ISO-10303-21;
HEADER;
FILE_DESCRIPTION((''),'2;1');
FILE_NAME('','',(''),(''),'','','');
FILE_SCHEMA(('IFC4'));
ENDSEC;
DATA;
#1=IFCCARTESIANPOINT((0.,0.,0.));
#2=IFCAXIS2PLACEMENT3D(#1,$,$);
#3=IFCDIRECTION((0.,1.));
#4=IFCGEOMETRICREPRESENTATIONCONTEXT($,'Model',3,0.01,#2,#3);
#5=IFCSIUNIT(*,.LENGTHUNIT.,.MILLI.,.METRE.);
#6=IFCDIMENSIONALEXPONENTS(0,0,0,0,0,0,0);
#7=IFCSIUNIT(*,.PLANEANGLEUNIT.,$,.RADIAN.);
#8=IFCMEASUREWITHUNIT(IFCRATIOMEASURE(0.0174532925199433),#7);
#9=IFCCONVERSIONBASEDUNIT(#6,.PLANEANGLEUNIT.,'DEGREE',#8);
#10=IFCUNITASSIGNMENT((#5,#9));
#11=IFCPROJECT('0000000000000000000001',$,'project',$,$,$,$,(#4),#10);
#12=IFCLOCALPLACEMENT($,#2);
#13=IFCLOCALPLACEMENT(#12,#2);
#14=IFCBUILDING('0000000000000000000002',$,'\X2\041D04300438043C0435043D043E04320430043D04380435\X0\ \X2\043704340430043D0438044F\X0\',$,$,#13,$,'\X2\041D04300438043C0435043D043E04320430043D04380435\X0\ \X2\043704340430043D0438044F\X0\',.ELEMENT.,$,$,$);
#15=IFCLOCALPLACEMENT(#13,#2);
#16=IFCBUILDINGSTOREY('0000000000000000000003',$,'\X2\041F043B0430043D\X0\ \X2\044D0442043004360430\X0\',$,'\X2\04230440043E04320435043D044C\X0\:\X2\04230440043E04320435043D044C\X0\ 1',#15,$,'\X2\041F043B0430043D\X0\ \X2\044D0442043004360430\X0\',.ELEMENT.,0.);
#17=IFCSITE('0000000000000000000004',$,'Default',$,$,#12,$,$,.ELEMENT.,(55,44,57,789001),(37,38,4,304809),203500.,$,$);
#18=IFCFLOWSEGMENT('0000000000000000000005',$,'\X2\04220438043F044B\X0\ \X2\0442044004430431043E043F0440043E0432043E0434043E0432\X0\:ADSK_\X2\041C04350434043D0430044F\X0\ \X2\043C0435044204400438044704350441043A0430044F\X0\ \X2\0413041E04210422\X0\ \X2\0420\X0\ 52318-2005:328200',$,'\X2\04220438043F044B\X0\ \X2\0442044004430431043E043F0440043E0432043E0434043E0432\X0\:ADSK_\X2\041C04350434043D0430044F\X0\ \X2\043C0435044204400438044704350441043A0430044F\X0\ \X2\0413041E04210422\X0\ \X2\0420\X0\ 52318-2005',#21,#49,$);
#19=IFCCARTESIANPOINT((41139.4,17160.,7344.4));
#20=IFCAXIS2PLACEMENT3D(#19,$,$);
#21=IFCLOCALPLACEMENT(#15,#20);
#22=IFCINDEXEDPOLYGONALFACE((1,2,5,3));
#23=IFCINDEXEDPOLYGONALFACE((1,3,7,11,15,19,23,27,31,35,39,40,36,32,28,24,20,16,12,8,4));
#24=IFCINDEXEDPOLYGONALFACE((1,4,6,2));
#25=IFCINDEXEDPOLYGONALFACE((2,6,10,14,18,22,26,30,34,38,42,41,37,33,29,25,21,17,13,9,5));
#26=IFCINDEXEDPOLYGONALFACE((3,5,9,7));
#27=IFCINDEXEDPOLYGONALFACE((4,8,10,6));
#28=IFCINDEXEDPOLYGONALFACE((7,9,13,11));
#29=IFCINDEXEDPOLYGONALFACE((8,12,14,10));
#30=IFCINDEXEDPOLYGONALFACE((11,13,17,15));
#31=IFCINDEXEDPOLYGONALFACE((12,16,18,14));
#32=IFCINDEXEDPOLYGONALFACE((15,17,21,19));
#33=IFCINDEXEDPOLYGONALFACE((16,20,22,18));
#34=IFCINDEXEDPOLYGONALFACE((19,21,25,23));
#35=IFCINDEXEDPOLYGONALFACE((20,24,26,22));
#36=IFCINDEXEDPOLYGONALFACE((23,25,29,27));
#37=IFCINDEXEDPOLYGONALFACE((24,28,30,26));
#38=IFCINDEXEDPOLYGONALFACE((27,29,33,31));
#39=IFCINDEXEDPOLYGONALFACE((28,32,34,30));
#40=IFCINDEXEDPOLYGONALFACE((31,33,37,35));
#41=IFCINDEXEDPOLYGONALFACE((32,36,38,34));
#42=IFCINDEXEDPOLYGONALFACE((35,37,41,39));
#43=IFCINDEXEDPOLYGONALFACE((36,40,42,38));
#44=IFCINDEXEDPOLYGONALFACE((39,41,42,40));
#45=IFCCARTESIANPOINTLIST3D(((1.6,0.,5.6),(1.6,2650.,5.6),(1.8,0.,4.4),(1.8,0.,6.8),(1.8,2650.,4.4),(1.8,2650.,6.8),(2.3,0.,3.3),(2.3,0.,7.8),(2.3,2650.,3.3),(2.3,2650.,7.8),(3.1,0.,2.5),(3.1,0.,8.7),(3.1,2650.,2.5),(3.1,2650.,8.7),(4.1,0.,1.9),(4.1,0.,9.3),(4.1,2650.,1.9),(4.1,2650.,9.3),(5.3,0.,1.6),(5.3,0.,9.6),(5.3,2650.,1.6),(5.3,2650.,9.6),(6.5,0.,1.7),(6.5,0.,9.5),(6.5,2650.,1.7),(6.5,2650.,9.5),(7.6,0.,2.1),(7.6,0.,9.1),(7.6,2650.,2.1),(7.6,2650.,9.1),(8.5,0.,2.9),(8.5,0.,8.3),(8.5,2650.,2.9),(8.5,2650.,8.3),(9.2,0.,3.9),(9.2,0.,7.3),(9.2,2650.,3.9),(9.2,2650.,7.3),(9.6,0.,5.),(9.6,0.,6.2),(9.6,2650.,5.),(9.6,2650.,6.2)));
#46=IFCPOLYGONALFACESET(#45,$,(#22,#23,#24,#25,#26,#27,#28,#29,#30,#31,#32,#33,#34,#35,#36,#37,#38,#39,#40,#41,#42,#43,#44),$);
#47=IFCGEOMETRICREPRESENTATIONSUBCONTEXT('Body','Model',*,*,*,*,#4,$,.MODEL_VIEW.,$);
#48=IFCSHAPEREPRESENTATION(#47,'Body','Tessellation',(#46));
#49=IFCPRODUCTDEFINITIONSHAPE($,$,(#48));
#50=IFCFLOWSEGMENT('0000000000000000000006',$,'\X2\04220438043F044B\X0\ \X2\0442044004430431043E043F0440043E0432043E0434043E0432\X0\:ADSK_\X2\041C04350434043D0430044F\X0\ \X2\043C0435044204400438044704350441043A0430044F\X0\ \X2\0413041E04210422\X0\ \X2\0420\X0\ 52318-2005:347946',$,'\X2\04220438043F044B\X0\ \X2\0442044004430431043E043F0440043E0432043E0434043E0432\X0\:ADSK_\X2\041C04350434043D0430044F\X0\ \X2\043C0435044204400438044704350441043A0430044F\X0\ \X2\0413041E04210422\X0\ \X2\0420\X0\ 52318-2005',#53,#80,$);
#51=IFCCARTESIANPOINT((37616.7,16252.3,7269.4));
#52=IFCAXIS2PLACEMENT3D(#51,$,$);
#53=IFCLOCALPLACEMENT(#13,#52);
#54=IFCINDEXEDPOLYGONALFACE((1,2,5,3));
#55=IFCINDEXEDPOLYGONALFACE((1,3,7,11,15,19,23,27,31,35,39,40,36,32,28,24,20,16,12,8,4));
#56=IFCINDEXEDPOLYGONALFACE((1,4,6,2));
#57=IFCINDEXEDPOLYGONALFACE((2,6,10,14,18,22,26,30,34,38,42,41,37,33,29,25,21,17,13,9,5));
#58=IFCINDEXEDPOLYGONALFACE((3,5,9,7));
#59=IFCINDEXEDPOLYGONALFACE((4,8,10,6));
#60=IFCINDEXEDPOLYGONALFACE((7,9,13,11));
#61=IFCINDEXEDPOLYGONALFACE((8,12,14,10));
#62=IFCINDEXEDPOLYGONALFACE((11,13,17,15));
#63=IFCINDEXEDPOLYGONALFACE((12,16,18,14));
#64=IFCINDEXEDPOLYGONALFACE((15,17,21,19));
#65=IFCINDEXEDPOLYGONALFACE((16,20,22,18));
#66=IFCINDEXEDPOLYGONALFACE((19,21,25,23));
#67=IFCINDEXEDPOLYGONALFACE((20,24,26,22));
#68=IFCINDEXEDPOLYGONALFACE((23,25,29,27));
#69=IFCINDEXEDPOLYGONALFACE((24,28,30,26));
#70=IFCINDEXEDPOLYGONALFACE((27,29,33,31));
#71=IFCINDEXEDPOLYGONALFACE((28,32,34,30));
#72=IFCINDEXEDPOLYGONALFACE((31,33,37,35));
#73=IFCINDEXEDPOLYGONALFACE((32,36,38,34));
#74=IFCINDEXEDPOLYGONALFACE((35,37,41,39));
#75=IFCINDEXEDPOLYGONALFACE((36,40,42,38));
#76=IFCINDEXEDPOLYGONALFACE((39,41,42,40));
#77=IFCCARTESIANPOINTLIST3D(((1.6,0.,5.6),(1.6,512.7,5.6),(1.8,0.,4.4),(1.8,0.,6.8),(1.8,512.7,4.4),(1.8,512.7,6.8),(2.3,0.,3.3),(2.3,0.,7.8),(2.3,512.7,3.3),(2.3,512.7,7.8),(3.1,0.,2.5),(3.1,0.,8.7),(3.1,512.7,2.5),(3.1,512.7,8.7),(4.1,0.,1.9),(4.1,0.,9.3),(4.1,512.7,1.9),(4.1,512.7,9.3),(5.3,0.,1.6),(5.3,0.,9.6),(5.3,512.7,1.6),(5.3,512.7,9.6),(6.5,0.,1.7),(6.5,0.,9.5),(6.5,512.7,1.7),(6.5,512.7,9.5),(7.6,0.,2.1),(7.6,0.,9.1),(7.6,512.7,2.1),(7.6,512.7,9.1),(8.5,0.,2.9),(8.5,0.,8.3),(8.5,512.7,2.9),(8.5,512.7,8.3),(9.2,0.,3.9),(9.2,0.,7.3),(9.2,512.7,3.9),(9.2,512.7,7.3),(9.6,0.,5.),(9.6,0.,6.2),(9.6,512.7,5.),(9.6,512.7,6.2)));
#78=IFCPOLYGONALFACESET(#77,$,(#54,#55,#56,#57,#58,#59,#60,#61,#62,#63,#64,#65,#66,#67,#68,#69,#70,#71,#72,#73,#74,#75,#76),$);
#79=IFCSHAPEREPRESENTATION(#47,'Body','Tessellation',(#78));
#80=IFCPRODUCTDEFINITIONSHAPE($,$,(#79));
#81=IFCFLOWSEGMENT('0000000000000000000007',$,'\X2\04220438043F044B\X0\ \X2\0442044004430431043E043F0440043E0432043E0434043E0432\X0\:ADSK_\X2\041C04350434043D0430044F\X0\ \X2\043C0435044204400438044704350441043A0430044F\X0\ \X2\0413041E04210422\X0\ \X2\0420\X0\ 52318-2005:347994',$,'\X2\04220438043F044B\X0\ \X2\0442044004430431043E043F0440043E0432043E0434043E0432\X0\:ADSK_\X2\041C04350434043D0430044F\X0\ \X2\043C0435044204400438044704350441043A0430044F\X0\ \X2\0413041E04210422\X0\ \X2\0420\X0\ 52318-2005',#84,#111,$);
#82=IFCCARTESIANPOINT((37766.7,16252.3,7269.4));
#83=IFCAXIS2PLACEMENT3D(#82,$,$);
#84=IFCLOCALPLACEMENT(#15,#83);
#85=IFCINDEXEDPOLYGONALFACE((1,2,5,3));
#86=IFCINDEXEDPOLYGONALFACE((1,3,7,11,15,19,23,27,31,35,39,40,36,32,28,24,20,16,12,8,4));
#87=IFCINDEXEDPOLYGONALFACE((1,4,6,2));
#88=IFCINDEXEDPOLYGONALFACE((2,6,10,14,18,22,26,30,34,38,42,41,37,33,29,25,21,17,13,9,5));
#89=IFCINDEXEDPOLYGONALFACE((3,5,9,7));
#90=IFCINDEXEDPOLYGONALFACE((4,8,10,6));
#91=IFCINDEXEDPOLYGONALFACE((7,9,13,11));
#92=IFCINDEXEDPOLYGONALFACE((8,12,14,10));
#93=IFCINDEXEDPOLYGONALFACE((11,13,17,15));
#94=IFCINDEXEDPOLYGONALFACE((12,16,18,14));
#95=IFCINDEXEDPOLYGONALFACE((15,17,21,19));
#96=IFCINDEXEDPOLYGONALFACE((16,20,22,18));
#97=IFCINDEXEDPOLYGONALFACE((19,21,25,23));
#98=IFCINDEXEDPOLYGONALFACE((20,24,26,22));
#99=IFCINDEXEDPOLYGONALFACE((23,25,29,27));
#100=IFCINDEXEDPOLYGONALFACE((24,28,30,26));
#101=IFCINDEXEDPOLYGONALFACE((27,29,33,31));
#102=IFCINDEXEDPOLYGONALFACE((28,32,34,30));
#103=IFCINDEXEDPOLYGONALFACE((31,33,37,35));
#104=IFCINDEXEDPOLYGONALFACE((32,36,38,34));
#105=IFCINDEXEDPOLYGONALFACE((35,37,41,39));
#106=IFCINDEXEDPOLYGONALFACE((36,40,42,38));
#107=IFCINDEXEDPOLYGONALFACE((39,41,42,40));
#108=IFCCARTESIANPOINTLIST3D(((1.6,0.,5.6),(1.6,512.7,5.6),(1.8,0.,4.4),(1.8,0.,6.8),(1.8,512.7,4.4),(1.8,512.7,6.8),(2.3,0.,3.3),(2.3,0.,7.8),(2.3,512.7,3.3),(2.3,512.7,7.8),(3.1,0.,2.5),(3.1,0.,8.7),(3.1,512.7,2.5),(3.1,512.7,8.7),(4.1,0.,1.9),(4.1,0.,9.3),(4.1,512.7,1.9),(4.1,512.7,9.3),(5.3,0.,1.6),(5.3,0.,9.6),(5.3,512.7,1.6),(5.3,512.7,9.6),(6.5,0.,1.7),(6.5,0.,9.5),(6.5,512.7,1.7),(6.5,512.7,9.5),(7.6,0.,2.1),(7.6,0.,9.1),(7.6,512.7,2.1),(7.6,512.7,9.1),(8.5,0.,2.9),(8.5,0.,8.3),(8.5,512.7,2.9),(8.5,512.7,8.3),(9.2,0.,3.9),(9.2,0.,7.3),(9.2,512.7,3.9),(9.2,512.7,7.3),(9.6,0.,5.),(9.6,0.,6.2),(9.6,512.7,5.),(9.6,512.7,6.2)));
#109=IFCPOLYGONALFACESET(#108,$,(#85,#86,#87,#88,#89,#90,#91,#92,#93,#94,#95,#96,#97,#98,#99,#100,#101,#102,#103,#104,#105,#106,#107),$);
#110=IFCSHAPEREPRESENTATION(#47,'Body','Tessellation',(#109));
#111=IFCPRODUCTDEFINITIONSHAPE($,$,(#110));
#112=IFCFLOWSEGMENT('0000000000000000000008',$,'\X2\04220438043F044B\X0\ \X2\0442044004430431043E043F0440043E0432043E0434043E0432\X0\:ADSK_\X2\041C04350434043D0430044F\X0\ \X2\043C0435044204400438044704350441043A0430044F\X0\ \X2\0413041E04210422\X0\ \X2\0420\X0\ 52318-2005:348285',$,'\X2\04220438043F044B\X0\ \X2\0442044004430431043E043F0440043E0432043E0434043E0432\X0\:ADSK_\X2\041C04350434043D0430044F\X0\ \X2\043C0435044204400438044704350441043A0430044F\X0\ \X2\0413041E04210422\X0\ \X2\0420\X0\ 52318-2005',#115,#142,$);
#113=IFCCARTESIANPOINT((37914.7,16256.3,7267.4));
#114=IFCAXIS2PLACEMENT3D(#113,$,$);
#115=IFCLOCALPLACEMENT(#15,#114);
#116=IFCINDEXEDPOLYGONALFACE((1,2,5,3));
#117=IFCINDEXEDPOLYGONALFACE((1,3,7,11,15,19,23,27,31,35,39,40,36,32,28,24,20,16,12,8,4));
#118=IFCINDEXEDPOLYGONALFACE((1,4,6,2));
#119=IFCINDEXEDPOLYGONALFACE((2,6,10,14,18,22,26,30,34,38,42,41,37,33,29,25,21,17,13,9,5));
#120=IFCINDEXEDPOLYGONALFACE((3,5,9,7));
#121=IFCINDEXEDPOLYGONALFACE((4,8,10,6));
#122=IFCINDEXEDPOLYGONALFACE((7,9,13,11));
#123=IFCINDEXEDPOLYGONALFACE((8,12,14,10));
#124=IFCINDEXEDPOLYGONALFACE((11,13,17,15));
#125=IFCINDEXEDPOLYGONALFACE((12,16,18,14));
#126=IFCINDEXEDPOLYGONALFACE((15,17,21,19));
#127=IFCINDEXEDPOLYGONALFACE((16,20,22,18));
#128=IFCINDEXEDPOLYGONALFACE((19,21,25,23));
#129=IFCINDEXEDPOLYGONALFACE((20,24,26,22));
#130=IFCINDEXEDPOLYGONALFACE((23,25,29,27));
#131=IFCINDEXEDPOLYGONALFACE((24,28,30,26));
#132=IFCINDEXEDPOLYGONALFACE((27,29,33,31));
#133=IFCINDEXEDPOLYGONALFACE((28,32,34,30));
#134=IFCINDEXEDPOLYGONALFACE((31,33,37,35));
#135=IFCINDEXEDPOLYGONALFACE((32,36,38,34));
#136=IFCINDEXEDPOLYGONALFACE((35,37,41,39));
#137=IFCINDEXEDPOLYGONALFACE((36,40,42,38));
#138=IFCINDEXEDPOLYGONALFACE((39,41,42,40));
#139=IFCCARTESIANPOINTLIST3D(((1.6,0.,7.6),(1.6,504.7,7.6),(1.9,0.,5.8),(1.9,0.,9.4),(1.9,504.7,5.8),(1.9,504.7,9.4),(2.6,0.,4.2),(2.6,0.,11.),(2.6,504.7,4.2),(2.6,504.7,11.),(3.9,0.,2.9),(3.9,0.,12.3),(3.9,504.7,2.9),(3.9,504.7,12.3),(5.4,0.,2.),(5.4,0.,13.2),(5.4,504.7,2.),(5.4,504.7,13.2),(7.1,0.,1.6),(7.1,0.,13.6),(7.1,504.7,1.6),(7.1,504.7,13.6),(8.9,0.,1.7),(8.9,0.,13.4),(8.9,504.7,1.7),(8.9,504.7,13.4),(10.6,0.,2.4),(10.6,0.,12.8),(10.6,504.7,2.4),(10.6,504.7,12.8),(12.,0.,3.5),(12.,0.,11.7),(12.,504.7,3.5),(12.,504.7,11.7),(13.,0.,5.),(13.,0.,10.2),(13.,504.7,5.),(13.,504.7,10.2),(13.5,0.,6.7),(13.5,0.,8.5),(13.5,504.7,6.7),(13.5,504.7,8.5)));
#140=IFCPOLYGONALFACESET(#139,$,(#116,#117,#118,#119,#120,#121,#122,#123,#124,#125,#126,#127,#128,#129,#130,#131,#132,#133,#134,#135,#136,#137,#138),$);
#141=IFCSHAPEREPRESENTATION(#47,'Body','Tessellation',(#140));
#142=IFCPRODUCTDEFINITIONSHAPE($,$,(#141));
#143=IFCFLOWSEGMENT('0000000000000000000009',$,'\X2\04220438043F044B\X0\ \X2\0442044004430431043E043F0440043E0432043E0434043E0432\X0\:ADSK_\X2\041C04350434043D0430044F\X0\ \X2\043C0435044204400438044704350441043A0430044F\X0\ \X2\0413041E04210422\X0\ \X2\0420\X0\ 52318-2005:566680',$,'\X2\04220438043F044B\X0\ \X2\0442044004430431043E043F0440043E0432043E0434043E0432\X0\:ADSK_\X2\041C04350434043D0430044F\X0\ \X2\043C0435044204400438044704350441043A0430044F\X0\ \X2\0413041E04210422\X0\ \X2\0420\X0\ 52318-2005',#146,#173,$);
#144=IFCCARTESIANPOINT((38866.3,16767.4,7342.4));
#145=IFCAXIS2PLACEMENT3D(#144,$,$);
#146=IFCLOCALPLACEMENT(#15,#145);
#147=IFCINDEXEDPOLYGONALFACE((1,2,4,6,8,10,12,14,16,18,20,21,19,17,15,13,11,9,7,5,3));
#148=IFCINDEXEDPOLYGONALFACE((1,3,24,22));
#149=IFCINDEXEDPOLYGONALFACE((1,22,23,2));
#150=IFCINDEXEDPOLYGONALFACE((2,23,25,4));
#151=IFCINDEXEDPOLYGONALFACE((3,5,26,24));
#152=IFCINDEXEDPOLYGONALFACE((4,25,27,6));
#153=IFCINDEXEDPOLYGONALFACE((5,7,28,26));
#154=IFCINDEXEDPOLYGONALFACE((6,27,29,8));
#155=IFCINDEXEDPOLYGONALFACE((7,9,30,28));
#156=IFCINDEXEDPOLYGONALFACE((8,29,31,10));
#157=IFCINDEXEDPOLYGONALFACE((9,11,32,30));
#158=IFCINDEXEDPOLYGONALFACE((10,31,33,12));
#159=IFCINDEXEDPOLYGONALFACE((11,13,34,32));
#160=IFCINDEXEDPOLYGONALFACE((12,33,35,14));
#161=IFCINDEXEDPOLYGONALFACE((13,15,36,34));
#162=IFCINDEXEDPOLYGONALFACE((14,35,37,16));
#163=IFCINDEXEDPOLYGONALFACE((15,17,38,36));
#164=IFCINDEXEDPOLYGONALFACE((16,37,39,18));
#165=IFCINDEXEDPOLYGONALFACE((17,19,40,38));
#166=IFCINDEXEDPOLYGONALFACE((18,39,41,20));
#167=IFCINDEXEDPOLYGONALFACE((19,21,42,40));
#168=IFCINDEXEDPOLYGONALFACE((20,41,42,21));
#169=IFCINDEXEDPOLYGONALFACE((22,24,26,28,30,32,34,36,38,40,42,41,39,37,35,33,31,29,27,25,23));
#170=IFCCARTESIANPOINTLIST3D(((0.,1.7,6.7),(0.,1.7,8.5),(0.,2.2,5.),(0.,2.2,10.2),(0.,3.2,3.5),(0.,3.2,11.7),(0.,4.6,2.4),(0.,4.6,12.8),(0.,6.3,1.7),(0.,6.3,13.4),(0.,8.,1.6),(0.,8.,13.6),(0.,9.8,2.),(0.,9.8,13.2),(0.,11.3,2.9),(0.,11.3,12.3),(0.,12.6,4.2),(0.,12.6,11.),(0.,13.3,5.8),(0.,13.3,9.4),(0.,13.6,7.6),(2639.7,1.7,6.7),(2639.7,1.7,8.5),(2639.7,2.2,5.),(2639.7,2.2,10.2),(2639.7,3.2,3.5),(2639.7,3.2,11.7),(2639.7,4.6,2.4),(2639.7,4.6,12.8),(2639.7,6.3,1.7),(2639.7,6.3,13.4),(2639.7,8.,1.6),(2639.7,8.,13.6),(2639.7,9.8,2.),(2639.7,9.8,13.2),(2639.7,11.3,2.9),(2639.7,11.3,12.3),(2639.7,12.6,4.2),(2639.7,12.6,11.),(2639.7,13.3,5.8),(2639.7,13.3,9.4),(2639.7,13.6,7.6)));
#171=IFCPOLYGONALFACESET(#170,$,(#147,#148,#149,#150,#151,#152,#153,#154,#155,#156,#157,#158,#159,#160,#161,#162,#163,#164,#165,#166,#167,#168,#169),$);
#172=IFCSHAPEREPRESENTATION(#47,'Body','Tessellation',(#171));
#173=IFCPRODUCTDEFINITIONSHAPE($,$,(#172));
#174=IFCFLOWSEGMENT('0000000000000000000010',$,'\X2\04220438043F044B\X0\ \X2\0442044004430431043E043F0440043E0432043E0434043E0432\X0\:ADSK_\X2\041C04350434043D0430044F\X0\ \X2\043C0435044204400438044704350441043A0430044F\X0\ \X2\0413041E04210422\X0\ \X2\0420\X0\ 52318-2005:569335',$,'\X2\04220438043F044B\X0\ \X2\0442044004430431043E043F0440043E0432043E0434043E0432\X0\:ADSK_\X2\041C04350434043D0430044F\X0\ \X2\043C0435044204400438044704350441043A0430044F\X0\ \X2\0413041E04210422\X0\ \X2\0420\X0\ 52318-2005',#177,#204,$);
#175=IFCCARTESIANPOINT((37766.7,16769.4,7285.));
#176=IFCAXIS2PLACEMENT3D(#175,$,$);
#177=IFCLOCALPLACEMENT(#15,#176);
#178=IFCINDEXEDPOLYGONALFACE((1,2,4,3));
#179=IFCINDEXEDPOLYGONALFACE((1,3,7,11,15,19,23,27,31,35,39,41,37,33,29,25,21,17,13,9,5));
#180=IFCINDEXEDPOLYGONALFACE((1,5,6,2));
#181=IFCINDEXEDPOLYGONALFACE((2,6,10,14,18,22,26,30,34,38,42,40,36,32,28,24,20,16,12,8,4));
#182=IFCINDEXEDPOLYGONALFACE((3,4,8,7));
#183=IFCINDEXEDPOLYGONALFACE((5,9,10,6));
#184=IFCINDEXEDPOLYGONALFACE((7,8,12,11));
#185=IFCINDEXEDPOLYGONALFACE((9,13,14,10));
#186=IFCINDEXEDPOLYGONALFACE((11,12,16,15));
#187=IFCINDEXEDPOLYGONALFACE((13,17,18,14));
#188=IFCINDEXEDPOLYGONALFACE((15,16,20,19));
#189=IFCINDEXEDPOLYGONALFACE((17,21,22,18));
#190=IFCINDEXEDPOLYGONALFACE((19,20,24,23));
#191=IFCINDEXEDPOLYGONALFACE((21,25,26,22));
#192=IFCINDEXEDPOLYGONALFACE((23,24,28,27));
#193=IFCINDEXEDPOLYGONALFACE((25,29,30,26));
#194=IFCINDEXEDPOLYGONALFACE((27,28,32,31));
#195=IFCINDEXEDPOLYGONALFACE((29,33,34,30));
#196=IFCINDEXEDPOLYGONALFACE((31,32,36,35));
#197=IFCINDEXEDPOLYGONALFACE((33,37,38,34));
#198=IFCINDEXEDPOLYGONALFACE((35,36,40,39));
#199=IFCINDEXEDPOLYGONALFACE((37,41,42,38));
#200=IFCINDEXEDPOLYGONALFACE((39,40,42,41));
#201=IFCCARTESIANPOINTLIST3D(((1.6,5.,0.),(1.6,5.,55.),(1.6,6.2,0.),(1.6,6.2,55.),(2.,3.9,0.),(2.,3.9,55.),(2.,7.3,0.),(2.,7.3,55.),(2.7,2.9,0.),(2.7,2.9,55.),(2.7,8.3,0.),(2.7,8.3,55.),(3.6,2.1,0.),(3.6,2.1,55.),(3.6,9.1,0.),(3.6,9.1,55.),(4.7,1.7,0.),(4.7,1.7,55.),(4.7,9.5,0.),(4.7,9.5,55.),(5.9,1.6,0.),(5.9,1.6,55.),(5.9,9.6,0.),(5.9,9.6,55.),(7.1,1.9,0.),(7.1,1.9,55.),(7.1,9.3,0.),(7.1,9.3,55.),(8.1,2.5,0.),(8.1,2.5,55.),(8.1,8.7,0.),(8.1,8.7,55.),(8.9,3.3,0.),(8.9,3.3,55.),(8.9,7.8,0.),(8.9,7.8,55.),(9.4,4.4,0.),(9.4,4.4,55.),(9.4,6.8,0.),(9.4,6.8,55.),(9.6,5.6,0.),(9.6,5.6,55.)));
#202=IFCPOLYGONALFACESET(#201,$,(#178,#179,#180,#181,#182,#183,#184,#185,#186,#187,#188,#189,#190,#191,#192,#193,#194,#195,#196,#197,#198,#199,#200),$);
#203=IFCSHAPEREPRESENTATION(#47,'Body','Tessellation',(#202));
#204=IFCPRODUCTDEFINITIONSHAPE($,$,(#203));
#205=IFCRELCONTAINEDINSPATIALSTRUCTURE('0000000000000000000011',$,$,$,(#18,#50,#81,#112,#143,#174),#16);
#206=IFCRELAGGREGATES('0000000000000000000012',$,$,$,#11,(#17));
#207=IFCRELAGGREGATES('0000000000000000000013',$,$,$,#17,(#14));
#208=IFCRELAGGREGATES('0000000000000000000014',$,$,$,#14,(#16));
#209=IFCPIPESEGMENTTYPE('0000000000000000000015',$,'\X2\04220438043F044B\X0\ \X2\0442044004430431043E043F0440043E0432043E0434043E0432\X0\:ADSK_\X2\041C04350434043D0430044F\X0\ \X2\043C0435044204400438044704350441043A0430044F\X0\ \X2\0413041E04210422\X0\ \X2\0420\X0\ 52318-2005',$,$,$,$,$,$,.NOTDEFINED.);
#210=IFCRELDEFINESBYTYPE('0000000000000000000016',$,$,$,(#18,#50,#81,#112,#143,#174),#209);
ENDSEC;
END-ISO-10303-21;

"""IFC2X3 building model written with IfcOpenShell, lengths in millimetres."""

from ifc_helpers import new_model, entity, si_unit, converted_unit, direction, frame, frame_2d, origin, origin_2d_with_axis, place, context, subcontext, project, spatial, circle, extrude, type_object, element, save


model = new_model("IFC2X3")

# Units and contexts
model_context = context("Model", 3, precision=0.01, world=origin(), true_north=direction((0.0, 1.0)))
body_context = subcontext(model_context, "Body", "Model", "MODEL_VIEW")
ifc_project = project(units=[si_unit("LENGTHUNIT", "METRE", prefix="MILLI"), converted_unit("PLANEANGLEUNIT", "DEGREE", entity("IfcRatioMeasure", 0.0174532925199433), si_unit("PLANEANGLEUNIT", "RADIAN"), dimensions=[0, 0, 0, 0, 0, 0, 0])], contexts=[model_context])

# Site, building, storey
site_placement = place(None, frame((0.0, 0.0, 0.0)))
site = spatial("IfcSite", under=ifc_project, at=site_placement, Name="Default", CompositionType="ELEMENT", RefLatitude=(55, 44, 57, 789001), RefLongitude=(37, 38, 4, 304809), RefElevation=203500.0)
building_placement = place(site_placement, origin())
building = spatial("IfcBuilding", under=site, at=building_placement, Name="Наименование здания", LongName="Наименование здания", CompositionType="ELEMENT")
storey_placement = place(building_placement, origin())
storey = spatial("IfcBuildingStorey", under=building, at=storey_placement, Name="План этажа", ObjectType="Уровень:Уровень 1", LongName="План этажа", CompositionType="ELEMENT", Elevation=0.0)

# Flow segments
pipe_segment_type = type_object("IfcPipeSegmentType", Name="Типы трубопроводов:ADSK_Медная метрическая ГОСТ Р 52318-2005", PredefinedType="NOTDEFINED")
flow_segment_1_placement = place(storey_placement, frame((41139.4, 17160.0, 7344.4)))
element("IfcFlowSegment", 1, at=flow_segment_1_placement, inside=storey, type_object=pipe_segment_type, Name="Типы трубопроводов:ADSK_Медная метрическая ГОСТ Р 52318-2005:328200", ObjectType="Типы трубопроводов:ADSK_Медная метрическая ГОСТ Р 52318-2005", context=body_context, shape_type="SweptSolid", body=[
    extrude(circle(Radius=4.0, at=frame_2d((0.0, 0.0), x_axis=(1.0, 0.0))), frame((5.6, 0.0, 5.6), z_axis=(0.0, 1.0, 0.0), x_axis=(-1.0, 0.0, 0.0)), (0.0, 0.0, 1.0), 2650.0),
])
flow_segment_2_placement = place(building_placement, frame((37616.7, 16252.3, 7269.4)))
element("IfcFlowSegment", 2, at=flow_segment_2_placement, inside=storey, type_object=pipe_segment_type, Name="Типы трубопроводов:ADSK_Медная метрическая ГОСТ Р 52318-2005:347946", ObjectType="Типы трубопроводов:ADSK_Медная метрическая ГОСТ Р 52318-2005", context=body_context, shape_type="SweptSolid", body=[
    extrude(circle(Radius=4.0, at=frame_2d((0.0, 0.0), x_axis=(1.0, 0.0))), frame((5.6, 0.0, 5.6), z_axis=(0.0, 1.0, 0.0), x_axis=(-1.0, 0.0, 0.0)), (0.0, 0.0, 1.0), 512.7),
])
flow_segment_3_placement = place(storey_placement, frame((37766.7, 16252.3, 7269.4)))
element("IfcFlowSegment", 3, at=flow_segment_3_placement, inside=storey, type_object=pipe_segment_type, Name="Типы трубопроводов:ADSK_Медная метрическая ГОСТ Р 52318-2005:347994", ObjectType="Типы трубопроводов:ADSK_Медная метрическая ГОСТ Р 52318-2005", context=body_context, shape_type="SweptSolid", body=[
    extrude(circle(Radius=4.0, at=frame_2d((0.0, 0.0), x_axis=(1.0, 0.0))), frame((5.6, 0.0, 5.6), z_axis=(0.0, 1.0, 0.0), x_axis=(-1.0, 0.0, 0.0)), (0.0, 0.0, 1.0), 512.7),
])
flow_segment_4_placement = place(storey_placement, frame((37914.7, 16256.3, 7267.4)))
element("IfcFlowSegment", 4, at=flow_segment_4_placement, inside=storey, type_object=pipe_segment_type, Name="Типы трубопроводов:ADSK_Медная метрическая ГОСТ Р 52318-2005:348285", ObjectType="Типы трубопроводов:ADSK_Медная метрическая ГОСТ Р 52318-2005", context=body_context, shape_type="SweptSolid", body=[
    extrude(circle(Radius=6.0, at=frame_2d((0.0, 0.0), x_axis=(1.0, 0.0))), frame((7.6, 0.0, 7.6), z_axis=(0.0, 1.0, 0.0), x_axis=(-1.0, 0.0, 0.0)), (0.0, 0.0, 1.0), 504.7),
])
flow_segment_5_placement = place(storey_placement, frame((38866.3, 16767.4, 7342.4)))
element("IfcFlowSegment", 5, at=flow_segment_5_placement, inside=storey, type_object=pipe_segment_type, Name="Типы трубопроводов:ADSK_Медная метрическая ГОСТ Р 52318-2005:566680", ObjectType="Типы трубопроводов:ADSK_Медная метрическая ГОСТ Р 52318-2005", context=body_context, shape_type="SweptSolid", body=[
    extrude(circle(Radius=6.0, at=frame_2d((0.0, 0.0), x_axis=(1.0, 0.0))), frame((0.0, 7.6, 7.6), z_axis=(1.0, 0.0, 0.0), x_axis=(0.0, 1.0, 0.0)), (0.0, 0.0, 1.0), 2639.7),
])
flow_segment_6_placement = place(storey_placement, frame((37766.7, 16769.4, 7285.0)))
element("IfcFlowSegment", 6, at=flow_segment_6_placement, inside=storey, type_object=pipe_segment_type, Name="Типы трубопроводов:ADSK_Медная метрическая ГОСТ Р 52318-2005:569335", ObjectType="Типы трубопроводов:ADSK_Медная метрическая ГОСТ Р 52318-2005", context=body_context, shape_type="SweptSolid", body=[
    extrude(circle(Radius=4.0, at=origin_2d_with_axis()), frame((5.6, 5.6, 0.0)), (0.0, 0.0, 1.0), 55.0),
])

save(model, "model.ifc")
